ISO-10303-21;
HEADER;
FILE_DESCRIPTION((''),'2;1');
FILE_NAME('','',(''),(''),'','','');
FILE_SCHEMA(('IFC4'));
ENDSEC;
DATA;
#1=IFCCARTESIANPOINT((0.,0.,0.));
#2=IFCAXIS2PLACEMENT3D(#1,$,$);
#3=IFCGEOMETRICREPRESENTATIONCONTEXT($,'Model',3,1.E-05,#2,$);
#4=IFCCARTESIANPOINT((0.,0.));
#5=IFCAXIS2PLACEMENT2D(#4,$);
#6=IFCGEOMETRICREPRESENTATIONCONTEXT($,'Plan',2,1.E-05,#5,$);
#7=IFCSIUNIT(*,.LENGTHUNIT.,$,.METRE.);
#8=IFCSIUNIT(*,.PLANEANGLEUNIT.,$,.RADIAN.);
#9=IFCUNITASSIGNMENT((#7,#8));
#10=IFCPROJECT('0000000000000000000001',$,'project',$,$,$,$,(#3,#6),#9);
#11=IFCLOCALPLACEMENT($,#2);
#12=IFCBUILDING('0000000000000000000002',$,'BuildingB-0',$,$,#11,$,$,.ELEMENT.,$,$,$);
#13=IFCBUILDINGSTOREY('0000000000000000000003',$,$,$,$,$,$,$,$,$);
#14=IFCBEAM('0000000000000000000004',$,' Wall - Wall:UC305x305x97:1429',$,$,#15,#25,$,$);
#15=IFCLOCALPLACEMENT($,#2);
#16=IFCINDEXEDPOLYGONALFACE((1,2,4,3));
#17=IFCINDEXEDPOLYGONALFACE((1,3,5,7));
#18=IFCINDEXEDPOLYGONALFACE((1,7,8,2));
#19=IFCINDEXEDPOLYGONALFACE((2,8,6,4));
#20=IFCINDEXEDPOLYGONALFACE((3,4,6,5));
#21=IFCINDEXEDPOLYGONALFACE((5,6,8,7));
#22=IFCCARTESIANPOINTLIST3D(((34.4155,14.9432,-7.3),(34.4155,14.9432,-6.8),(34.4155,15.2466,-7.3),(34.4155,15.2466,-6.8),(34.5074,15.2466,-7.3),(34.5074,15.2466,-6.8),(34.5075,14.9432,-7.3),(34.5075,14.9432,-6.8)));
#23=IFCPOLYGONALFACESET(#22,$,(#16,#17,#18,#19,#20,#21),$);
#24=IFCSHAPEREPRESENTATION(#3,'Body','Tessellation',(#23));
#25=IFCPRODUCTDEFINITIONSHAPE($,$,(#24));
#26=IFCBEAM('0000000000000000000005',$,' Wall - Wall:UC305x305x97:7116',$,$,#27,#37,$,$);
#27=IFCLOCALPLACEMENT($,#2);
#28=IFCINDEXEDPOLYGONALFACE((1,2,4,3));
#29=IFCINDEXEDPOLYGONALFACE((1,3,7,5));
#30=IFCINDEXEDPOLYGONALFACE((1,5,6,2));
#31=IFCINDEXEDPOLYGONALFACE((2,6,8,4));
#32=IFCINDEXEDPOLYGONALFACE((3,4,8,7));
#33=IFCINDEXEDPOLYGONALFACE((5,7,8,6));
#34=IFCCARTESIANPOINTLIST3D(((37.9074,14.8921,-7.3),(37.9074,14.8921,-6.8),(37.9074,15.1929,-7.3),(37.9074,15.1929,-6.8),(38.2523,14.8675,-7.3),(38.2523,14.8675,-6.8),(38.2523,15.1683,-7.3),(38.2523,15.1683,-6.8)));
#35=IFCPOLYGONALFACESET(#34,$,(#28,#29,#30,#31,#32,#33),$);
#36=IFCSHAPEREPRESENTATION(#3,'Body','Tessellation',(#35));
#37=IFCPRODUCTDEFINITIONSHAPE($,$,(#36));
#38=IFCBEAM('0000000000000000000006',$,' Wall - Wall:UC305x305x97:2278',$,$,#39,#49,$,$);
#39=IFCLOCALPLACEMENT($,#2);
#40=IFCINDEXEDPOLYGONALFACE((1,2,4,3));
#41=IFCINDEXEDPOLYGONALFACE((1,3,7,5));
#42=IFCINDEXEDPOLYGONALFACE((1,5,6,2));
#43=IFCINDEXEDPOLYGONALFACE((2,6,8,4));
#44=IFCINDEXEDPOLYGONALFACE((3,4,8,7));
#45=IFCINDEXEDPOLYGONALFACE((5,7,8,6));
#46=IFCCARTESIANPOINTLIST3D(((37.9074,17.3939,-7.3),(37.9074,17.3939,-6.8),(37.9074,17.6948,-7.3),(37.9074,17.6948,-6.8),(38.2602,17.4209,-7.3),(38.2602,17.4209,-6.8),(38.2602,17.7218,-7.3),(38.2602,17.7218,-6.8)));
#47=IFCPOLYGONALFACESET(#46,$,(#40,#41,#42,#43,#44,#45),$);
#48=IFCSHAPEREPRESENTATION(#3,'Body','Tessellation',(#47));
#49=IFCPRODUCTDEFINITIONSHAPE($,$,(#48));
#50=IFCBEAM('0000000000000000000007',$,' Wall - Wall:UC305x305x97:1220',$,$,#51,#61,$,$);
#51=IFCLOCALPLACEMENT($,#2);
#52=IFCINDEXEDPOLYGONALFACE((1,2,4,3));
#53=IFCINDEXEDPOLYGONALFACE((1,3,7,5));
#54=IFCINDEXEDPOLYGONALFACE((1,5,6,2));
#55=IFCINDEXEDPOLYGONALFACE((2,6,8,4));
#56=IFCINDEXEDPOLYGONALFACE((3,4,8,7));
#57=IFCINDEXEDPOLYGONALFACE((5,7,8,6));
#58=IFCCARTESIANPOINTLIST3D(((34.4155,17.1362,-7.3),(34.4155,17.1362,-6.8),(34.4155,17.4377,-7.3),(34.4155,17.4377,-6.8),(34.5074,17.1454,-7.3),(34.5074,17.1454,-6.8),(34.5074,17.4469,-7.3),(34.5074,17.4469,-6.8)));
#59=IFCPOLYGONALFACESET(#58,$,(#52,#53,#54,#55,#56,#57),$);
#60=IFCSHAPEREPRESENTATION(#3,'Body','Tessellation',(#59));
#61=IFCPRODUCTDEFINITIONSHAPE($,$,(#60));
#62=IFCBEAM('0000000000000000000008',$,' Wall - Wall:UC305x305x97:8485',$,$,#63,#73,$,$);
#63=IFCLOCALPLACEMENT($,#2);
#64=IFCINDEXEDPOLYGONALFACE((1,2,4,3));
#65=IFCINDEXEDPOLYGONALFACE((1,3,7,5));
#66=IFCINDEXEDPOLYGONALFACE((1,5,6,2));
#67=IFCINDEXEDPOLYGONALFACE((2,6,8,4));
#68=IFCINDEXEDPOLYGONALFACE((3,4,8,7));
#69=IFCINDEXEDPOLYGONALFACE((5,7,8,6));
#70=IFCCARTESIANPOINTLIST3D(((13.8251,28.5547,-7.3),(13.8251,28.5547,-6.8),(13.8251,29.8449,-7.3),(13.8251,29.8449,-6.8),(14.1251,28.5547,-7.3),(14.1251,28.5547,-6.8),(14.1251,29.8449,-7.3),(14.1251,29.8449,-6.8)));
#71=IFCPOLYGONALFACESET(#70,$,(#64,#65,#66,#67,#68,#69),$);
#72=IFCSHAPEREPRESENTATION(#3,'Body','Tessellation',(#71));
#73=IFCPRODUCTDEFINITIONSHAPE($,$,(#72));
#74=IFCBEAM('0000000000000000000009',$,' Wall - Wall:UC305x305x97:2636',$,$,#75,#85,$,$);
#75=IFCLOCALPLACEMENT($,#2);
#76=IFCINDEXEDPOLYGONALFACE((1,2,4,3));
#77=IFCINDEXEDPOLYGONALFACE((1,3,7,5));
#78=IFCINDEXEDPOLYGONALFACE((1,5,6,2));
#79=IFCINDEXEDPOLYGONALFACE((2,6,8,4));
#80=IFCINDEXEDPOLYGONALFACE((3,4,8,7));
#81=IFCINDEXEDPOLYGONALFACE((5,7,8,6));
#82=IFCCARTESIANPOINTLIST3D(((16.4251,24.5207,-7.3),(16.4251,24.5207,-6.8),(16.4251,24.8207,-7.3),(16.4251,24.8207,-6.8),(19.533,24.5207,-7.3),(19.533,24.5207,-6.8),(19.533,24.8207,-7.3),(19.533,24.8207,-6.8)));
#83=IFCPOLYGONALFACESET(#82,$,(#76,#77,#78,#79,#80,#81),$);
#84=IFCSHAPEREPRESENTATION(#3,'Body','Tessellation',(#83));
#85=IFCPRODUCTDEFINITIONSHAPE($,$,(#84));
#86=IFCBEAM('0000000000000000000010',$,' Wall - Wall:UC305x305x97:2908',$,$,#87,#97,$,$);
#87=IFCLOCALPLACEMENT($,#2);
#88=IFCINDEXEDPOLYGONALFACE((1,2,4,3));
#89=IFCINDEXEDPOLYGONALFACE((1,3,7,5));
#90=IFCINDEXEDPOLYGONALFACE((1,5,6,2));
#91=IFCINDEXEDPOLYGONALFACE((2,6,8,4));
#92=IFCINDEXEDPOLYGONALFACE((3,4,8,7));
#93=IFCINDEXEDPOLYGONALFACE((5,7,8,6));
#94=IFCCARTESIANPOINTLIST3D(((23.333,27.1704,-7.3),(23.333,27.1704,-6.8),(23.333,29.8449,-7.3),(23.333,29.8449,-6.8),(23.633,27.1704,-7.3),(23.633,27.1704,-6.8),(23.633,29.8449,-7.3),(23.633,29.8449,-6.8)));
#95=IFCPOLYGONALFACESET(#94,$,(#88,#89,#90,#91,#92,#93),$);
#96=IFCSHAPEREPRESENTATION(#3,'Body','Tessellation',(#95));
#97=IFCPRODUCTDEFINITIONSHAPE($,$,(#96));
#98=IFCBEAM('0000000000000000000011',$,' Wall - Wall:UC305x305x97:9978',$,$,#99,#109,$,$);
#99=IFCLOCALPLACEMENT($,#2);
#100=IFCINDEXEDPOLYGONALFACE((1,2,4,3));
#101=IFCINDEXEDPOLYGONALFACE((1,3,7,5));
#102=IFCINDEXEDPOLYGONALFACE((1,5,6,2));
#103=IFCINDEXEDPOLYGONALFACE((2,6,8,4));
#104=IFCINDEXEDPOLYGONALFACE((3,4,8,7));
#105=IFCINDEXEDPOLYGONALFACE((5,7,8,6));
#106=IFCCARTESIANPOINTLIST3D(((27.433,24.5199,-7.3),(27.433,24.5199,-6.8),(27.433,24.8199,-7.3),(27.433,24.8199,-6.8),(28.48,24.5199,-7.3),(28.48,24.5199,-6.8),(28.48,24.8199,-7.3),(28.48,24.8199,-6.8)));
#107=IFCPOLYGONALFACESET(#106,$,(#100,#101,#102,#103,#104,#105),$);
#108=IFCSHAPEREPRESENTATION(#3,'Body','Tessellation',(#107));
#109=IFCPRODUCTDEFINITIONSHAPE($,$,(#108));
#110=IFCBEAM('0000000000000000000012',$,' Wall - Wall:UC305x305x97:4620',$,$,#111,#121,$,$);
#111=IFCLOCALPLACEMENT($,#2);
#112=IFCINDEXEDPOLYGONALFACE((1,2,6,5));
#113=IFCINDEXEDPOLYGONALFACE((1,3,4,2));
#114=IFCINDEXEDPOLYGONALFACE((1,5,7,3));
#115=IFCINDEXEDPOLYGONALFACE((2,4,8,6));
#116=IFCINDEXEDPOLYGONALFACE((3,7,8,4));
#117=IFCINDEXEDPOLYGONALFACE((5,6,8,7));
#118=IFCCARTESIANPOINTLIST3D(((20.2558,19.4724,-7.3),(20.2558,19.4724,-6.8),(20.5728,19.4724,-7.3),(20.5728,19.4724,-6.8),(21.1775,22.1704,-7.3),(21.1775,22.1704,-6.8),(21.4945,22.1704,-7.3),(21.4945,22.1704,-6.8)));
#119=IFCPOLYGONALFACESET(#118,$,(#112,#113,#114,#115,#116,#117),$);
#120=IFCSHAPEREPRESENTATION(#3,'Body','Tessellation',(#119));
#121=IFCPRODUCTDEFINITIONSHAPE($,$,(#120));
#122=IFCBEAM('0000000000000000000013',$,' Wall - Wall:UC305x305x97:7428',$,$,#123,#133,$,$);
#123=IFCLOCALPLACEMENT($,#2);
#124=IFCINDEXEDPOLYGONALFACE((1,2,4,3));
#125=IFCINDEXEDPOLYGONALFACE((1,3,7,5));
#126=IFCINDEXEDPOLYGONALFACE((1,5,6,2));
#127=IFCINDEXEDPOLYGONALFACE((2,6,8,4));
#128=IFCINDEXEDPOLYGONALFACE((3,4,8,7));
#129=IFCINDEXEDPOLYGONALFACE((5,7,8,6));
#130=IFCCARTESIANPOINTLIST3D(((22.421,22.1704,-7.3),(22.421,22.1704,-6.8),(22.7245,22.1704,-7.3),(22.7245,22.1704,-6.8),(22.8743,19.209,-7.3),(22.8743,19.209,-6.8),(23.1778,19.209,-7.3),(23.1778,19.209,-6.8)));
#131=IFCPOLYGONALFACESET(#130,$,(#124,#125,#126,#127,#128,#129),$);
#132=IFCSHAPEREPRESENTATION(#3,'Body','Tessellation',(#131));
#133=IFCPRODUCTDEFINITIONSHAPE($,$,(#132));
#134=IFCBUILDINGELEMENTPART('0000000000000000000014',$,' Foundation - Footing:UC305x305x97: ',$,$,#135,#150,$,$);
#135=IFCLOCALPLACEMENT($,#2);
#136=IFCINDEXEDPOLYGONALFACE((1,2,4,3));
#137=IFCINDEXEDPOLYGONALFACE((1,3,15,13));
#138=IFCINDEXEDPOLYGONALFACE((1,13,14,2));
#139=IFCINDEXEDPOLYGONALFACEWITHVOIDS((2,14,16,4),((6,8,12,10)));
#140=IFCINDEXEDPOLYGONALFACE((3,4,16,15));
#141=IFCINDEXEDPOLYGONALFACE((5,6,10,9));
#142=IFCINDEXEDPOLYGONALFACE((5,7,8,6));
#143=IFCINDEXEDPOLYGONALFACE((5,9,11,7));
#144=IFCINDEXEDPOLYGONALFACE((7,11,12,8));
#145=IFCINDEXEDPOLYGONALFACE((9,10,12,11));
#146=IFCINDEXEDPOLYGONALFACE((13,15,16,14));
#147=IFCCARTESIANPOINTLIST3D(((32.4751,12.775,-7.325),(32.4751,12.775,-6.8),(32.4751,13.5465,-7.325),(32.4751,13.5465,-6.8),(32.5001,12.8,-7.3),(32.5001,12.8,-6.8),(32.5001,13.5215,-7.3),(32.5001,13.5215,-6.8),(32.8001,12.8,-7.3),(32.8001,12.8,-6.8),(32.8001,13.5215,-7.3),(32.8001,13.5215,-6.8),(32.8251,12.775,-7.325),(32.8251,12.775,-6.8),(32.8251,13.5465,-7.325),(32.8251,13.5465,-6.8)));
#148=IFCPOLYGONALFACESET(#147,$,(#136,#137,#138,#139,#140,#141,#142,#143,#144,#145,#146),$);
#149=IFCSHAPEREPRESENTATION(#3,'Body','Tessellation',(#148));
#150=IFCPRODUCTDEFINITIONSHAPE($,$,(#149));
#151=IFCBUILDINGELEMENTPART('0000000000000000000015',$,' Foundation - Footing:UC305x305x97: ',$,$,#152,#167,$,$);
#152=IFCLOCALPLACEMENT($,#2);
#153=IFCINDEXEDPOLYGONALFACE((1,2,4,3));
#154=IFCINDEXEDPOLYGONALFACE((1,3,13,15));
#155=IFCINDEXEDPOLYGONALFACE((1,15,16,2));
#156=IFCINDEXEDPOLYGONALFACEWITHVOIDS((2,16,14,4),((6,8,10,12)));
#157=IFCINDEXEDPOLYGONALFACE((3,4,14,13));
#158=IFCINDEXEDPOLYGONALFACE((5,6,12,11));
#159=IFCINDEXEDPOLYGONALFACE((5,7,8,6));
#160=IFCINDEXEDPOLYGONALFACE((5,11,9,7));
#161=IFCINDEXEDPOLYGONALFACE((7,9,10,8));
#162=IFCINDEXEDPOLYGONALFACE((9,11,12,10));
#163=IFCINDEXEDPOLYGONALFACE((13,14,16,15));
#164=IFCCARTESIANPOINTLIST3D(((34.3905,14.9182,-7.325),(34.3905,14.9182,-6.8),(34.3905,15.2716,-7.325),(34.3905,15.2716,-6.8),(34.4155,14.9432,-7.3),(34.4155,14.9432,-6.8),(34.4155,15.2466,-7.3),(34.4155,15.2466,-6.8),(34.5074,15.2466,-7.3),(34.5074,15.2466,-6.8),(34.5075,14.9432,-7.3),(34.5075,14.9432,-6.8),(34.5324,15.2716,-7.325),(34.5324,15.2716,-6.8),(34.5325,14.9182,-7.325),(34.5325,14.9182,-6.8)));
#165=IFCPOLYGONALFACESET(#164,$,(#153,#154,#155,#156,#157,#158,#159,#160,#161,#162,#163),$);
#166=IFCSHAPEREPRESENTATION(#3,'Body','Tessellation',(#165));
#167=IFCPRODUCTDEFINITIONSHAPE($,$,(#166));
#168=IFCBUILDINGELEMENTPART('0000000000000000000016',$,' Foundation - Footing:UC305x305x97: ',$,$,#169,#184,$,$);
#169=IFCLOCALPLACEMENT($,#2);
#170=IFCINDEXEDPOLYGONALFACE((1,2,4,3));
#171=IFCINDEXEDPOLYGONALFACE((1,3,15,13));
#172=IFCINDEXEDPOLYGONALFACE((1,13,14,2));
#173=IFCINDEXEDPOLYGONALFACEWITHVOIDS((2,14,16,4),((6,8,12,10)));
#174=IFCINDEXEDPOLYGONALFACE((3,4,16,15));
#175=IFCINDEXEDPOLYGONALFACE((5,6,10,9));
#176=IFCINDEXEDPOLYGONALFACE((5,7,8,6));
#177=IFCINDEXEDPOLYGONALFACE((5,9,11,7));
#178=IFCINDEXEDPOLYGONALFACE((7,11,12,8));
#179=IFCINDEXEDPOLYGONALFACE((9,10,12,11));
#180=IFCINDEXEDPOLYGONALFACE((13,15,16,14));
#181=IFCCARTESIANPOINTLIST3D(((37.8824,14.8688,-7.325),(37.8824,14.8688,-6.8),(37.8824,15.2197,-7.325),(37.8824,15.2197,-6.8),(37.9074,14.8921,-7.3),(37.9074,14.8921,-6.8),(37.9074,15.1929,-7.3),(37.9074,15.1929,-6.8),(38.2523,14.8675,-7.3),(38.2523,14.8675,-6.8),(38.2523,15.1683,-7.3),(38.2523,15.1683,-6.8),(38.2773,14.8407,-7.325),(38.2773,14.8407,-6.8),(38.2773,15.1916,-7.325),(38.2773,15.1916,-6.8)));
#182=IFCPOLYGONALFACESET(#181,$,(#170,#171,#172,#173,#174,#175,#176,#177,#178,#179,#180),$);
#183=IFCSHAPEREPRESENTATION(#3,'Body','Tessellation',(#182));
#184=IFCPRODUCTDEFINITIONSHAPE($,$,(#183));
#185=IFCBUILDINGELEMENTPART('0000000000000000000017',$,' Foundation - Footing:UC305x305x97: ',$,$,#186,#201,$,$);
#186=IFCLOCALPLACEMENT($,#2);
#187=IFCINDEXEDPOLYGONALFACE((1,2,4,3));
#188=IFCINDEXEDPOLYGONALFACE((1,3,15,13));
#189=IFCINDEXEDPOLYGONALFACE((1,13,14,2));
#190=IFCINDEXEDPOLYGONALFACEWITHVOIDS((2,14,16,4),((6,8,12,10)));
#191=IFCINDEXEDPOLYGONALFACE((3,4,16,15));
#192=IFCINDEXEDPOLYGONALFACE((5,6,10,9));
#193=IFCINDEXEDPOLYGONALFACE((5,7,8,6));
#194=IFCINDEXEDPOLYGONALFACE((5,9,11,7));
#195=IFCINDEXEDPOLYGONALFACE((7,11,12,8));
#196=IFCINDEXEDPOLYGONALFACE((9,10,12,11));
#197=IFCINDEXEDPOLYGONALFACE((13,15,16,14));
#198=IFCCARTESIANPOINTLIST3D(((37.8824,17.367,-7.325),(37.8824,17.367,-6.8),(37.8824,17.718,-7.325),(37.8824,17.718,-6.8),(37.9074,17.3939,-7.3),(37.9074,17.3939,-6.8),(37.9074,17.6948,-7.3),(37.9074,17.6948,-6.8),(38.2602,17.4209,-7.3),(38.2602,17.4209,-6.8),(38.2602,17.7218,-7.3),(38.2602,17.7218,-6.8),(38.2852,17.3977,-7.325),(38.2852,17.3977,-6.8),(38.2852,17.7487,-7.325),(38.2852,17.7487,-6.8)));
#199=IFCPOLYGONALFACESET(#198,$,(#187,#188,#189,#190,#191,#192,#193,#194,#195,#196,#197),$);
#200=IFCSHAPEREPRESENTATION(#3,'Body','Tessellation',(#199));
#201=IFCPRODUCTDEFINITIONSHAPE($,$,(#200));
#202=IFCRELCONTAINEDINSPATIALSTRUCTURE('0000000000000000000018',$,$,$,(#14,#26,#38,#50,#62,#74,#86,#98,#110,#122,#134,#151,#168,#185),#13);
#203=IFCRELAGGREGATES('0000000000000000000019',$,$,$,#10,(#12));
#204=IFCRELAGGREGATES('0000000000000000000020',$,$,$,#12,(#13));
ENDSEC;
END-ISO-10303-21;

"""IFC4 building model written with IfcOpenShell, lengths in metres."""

from ifc_helpers import new_model, si_unit, origin, origin_2d, place, context, project, spatial, polyline, outline, extrude, element, save


model = new_model("IFC4")

# Units and contexts
model_context = context("Model", 3, precision=1e-05, world=origin())
plan_context = context("Plan", 2, precision=1e-05, world=origin_2d())
ifc_project = project(units=[si_unit("LENGTHUNIT", "METRE"), si_unit("PLANEANGLEUNIT", "RADIAN")], contexts=[model_context, plan_context])

# Building, storey
building_placement = place(None, origin())
building = spatial("IfcBuilding", under=ifc_project, at=building_placement, Name="BuildingB-0", CompositionType="ELEMENT")
storey = spatial("IfcBuildingStorey", under=building)

# Beams
element("IfcBeam", 1, inside=storey, Name=" Wall - Wall:UC305x305x97:1429", context=model_context, shape_type="SweptSolid", body=[
    extrude(outline(polyline([(34.4155, 14.9432, -7.3), (34.5075, 14.9432, -7.3), (34.5074, 15.2466, -7.3), (34.4155, 15.2466, -7.3), (34.4155, 14.9432, -7.3)])), None, (0.0, 0.0, 1.0), 0.5),
])
element("IfcBeam", 2, inside=storey, Name=" Wall - Wall:UC305x305x97:7116", context=model_context, shape_type="SweptSolid", body=[
    extrude(outline(polyline([(37.9074, 14.8921, -7.3), (38.2523, 14.8675, -7.3), (38.2523, 15.1683, -7.3), (37.9074, 15.1929, -7.3), (37.9074, 14.8921, -7.3)])), None, (0.0, 0.0, 1.0), 0.5),
])
element("IfcBeam", 3, inside=storey, Name=" Wall - Wall:UC305x305x97:2278", context=model_context, shape_type="SweptSolid", body=[
    extrude(outline(polyline([(37.9074, 17.3939, -7.3), (38.2602, 17.4209, -7.3), (38.2602, 17.7218, -7.3), (37.9074, 17.6948, -7.3), (37.9074, 17.3939, -7.3)])), None, (0.0, 0.0, 1.0), 0.5),
])
element("IfcBeam", 4, inside=storey, Name=" Wall - Wall:UC305x305x97:1220", context=model_context, shape_type="SweptSolid", body=[
    extrude(outline(polyline([(34.4155, 17.1362, -7.3), (34.5074, 17.1454, -7.3), (34.5074, 17.4469, -7.3), (34.4155, 17.4377, -7.3), (34.4155, 17.1362, -7.3)])), None, (0.0, 0.0, 1.0), 0.5),
])
element("IfcBeam", 5, inside=storey, Name=" Wall - Wall:UC305x305x97:8485", context=model_context, shape_type="SweptSolid", body=[
    extrude(outline(polyline([(13.8251, 28.5547, -7.3), (14.1251, 28.5547, -7.3), (14.1251, 29.8449, -7.3), (13.8251, 29.8449, -7.3), (13.8251, 28.5547, -7.3)])), None, (0.0, 0.0, 1.0), 0.5),
])
element("IfcBeam", 6, inside=storey, Name=" Wall - Wall:UC305x305x97:2636", context=model_context, shape_type="SweptSolid", body=[
    extrude(outline(polyline([(16.4251, 24.5207, -7.3), (16.4251, 24.8207, -7.3), (19.533, 24.8207, -7.3), (19.533, 24.5207, -7.3), (16.4251, 24.5207, -7.3)])), None, (0.0, 0.0, 1.0), 0.5),
])
element("IfcBeam", 7, inside=storey, Name=" Wall - Wall:UC305x305x97:2908", context=model_context, shape_type="SweptSolid", body=[
    extrude(outline(polyline([(23.333, 27.1704, -7.3), (23.633, 27.1704, -7.3), (23.633, 29.8449, -7.3), (23.333, 29.8449, -7.3), (23.333, 27.1704, -7.3)])), None, (0.0, 0.0, 1.0), 0.5),
])
element("IfcBeam", 8, inside=storey, Name=" Wall - Wall:UC305x305x97:9978", context=model_context, shape_type="SweptSolid", body=[
    extrude(outline(polyline([(27.433, 24.5199, -7.3), (27.433, 24.8199, -7.3), (28.48, 24.8199, -7.3), (28.48, 24.5199, -7.3), (27.433, 24.5199, -7.3)])), None, (0.0, 0.0, 1.0), 0.5),
])
element("IfcBeam", 9, inside=storey, Name=" Wall - Wall:UC305x305x97:4620", context=model_context, shape_type="SweptSolid", body=[
    extrude(outline(polyline([(20.2558, 19.4724, -7.3), (20.5728, 19.4724, -7.3), (21.4945, 22.1704, -7.3), (21.1775, 22.1704, -7.3), (20.2558, 19.4724, -7.3)])), None, (0.0, 0.0, 1.0), 0.5),
])
element("IfcBeam", 10, inside=storey, Name=" Wall - Wall:UC305x305x97:7428", context=model_context, shape_type="SweptSolid", body=[
    extrude(outline(polyline([(22.8743, 19.209, -7.3), (23.1778, 19.209, -7.3), (22.7245, 22.1704, -7.3), (22.421, 22.1704, -7.3), (22.8743, 19.209, -7.3)])), None, (0.0, 0.0, 1.0), 0.5),
])

# Building element parts, openings
building_element_part_1 = element("IfcBuildingElementPart", 11, inside=storey, Name=" Foundation - Footing:UC305x305x97: ", context=model_context, shape_type="SweptSolid", body=[
    extrude(outline(polyline([(32.4751, 12.775, -7.325), (32.8251, 12.775, -7.325), (32.8251, 13.5465, -7.325), (32.4751, 13.5465, -7.325), (32.4751, 12.775, -7.325)])), None, (0.0, 0.0, 1.0), 0.525),
])
element("IfcOpeningElement", 12, inside=storey, cuts=building_element_part_1, context=model_context, shape_type="SweptSolid", body=[
    extrude(outline(polyline([(32.5001, 12.8, -7.3), (32.8001, 12.8, -7.3), (32.8001, 13.5215, -7.3), (32.5001, 13.5215, -7.3), (32.5001, 12.8, -7.3)])), None, (0.0, 0.0, 1.0), 0.5),
])
building_element_part_2 = element("IfcBuildingElementPart", 13, inside=storey, Name=" Foundation - Footing:UC305x305x97: ", context=model_context, shape_type="SweptSolid", body=[
    extrude(outline(polyline([(34.3905, 14.9182, -7.325), (34.5325, 14.9182, -7.325), (34.5324, 15.2716, -7.325), (34.3905, 15.2716, -7.325), (34.3905, 14.9182, -7.325)])), None, (0.0, 0.0, 1.0), 0.525),
])
element("IfcOpeningElement", 14, inside=storey, cuts=building_element_part_2, context=model_context, shape_type="SweptSolid", body=[
    extrude(outline(polyline([(34.4155, 14.9432, -7.3), (34.5075, 14.9432, -7.3), (34.5074, 15.2466, -7.3), (34.4155, 15.2466, -7.3), (34.4155, 14.9432, -7.3)])), None, (0.0, 0.0, 1.0), 0.5),
])
building_element_part_3 = element("IfcBuildingElementPart", 15, inside=storey, Name=" Foundation - Footing:UC305x305x97: ", context=model_context, shape_type="SweptSolid", body=[
    extrude(outline(polyline([(37.8824, 14.8688, -7.325), (38.2773, 14.8407, -7.325), (38.2773, 15.1916, -7.325), (37.8824, 15.2197, -7.325), (37.8824, 14.8688, -7.325)])), None, (0.0, 0.0, 1.0), 0.525),
])
element("IfcOpeningElement", 16, inside=storey, cuts=building_element_part_3, context=model_context, shape_type="SweptSolid", body=[
    extrude(outline(polyline([(37.9074, 14.8921, -7.3), (38.2523, 14.8675, -7.3), (38.2523, 15.1683, -7.3), (37.9074, 15.1929, -7.3), (37.9074, 14.8921, -7.3)])), None, (0.0, 0.0, 1.0), 0.5),
])
building_element_part_4 = element("IfcBuildingElementPart", 17, inside=storey, Name=" Foundation - Footing:UC305x305x97: ", context=model_context, shape_type="SweptSolid", body=[
    extrude(outline(polyline([(37.8824, 17.367, -7.325), (38.2852, 17.3977, -7.325), (38.2852, 17.7487, -7.325), (37.8824, 17.718, -7.325), (37.8824, 17.367, -7.325)])), None, (0.0, 0.0, 1.0), 0.525),
])
element("IfcOpeningElement", 18, inside=storey, cuts=building_element_part_4, context=model_context, shape_type="SweptSolid", body=[
    extrude(outline(polyline([(37.9074, 17.3939, -7.3), (38.2602, 17.4209, -7.3), (38.2602, 17.7218, -7.3), (37.9074, 17.6948, -7.3), (37.9074, 17.3939, -7.3)])), None, (0.0, 0.0, 1.0), 0.5),
])

save(model, "model.ifc")
